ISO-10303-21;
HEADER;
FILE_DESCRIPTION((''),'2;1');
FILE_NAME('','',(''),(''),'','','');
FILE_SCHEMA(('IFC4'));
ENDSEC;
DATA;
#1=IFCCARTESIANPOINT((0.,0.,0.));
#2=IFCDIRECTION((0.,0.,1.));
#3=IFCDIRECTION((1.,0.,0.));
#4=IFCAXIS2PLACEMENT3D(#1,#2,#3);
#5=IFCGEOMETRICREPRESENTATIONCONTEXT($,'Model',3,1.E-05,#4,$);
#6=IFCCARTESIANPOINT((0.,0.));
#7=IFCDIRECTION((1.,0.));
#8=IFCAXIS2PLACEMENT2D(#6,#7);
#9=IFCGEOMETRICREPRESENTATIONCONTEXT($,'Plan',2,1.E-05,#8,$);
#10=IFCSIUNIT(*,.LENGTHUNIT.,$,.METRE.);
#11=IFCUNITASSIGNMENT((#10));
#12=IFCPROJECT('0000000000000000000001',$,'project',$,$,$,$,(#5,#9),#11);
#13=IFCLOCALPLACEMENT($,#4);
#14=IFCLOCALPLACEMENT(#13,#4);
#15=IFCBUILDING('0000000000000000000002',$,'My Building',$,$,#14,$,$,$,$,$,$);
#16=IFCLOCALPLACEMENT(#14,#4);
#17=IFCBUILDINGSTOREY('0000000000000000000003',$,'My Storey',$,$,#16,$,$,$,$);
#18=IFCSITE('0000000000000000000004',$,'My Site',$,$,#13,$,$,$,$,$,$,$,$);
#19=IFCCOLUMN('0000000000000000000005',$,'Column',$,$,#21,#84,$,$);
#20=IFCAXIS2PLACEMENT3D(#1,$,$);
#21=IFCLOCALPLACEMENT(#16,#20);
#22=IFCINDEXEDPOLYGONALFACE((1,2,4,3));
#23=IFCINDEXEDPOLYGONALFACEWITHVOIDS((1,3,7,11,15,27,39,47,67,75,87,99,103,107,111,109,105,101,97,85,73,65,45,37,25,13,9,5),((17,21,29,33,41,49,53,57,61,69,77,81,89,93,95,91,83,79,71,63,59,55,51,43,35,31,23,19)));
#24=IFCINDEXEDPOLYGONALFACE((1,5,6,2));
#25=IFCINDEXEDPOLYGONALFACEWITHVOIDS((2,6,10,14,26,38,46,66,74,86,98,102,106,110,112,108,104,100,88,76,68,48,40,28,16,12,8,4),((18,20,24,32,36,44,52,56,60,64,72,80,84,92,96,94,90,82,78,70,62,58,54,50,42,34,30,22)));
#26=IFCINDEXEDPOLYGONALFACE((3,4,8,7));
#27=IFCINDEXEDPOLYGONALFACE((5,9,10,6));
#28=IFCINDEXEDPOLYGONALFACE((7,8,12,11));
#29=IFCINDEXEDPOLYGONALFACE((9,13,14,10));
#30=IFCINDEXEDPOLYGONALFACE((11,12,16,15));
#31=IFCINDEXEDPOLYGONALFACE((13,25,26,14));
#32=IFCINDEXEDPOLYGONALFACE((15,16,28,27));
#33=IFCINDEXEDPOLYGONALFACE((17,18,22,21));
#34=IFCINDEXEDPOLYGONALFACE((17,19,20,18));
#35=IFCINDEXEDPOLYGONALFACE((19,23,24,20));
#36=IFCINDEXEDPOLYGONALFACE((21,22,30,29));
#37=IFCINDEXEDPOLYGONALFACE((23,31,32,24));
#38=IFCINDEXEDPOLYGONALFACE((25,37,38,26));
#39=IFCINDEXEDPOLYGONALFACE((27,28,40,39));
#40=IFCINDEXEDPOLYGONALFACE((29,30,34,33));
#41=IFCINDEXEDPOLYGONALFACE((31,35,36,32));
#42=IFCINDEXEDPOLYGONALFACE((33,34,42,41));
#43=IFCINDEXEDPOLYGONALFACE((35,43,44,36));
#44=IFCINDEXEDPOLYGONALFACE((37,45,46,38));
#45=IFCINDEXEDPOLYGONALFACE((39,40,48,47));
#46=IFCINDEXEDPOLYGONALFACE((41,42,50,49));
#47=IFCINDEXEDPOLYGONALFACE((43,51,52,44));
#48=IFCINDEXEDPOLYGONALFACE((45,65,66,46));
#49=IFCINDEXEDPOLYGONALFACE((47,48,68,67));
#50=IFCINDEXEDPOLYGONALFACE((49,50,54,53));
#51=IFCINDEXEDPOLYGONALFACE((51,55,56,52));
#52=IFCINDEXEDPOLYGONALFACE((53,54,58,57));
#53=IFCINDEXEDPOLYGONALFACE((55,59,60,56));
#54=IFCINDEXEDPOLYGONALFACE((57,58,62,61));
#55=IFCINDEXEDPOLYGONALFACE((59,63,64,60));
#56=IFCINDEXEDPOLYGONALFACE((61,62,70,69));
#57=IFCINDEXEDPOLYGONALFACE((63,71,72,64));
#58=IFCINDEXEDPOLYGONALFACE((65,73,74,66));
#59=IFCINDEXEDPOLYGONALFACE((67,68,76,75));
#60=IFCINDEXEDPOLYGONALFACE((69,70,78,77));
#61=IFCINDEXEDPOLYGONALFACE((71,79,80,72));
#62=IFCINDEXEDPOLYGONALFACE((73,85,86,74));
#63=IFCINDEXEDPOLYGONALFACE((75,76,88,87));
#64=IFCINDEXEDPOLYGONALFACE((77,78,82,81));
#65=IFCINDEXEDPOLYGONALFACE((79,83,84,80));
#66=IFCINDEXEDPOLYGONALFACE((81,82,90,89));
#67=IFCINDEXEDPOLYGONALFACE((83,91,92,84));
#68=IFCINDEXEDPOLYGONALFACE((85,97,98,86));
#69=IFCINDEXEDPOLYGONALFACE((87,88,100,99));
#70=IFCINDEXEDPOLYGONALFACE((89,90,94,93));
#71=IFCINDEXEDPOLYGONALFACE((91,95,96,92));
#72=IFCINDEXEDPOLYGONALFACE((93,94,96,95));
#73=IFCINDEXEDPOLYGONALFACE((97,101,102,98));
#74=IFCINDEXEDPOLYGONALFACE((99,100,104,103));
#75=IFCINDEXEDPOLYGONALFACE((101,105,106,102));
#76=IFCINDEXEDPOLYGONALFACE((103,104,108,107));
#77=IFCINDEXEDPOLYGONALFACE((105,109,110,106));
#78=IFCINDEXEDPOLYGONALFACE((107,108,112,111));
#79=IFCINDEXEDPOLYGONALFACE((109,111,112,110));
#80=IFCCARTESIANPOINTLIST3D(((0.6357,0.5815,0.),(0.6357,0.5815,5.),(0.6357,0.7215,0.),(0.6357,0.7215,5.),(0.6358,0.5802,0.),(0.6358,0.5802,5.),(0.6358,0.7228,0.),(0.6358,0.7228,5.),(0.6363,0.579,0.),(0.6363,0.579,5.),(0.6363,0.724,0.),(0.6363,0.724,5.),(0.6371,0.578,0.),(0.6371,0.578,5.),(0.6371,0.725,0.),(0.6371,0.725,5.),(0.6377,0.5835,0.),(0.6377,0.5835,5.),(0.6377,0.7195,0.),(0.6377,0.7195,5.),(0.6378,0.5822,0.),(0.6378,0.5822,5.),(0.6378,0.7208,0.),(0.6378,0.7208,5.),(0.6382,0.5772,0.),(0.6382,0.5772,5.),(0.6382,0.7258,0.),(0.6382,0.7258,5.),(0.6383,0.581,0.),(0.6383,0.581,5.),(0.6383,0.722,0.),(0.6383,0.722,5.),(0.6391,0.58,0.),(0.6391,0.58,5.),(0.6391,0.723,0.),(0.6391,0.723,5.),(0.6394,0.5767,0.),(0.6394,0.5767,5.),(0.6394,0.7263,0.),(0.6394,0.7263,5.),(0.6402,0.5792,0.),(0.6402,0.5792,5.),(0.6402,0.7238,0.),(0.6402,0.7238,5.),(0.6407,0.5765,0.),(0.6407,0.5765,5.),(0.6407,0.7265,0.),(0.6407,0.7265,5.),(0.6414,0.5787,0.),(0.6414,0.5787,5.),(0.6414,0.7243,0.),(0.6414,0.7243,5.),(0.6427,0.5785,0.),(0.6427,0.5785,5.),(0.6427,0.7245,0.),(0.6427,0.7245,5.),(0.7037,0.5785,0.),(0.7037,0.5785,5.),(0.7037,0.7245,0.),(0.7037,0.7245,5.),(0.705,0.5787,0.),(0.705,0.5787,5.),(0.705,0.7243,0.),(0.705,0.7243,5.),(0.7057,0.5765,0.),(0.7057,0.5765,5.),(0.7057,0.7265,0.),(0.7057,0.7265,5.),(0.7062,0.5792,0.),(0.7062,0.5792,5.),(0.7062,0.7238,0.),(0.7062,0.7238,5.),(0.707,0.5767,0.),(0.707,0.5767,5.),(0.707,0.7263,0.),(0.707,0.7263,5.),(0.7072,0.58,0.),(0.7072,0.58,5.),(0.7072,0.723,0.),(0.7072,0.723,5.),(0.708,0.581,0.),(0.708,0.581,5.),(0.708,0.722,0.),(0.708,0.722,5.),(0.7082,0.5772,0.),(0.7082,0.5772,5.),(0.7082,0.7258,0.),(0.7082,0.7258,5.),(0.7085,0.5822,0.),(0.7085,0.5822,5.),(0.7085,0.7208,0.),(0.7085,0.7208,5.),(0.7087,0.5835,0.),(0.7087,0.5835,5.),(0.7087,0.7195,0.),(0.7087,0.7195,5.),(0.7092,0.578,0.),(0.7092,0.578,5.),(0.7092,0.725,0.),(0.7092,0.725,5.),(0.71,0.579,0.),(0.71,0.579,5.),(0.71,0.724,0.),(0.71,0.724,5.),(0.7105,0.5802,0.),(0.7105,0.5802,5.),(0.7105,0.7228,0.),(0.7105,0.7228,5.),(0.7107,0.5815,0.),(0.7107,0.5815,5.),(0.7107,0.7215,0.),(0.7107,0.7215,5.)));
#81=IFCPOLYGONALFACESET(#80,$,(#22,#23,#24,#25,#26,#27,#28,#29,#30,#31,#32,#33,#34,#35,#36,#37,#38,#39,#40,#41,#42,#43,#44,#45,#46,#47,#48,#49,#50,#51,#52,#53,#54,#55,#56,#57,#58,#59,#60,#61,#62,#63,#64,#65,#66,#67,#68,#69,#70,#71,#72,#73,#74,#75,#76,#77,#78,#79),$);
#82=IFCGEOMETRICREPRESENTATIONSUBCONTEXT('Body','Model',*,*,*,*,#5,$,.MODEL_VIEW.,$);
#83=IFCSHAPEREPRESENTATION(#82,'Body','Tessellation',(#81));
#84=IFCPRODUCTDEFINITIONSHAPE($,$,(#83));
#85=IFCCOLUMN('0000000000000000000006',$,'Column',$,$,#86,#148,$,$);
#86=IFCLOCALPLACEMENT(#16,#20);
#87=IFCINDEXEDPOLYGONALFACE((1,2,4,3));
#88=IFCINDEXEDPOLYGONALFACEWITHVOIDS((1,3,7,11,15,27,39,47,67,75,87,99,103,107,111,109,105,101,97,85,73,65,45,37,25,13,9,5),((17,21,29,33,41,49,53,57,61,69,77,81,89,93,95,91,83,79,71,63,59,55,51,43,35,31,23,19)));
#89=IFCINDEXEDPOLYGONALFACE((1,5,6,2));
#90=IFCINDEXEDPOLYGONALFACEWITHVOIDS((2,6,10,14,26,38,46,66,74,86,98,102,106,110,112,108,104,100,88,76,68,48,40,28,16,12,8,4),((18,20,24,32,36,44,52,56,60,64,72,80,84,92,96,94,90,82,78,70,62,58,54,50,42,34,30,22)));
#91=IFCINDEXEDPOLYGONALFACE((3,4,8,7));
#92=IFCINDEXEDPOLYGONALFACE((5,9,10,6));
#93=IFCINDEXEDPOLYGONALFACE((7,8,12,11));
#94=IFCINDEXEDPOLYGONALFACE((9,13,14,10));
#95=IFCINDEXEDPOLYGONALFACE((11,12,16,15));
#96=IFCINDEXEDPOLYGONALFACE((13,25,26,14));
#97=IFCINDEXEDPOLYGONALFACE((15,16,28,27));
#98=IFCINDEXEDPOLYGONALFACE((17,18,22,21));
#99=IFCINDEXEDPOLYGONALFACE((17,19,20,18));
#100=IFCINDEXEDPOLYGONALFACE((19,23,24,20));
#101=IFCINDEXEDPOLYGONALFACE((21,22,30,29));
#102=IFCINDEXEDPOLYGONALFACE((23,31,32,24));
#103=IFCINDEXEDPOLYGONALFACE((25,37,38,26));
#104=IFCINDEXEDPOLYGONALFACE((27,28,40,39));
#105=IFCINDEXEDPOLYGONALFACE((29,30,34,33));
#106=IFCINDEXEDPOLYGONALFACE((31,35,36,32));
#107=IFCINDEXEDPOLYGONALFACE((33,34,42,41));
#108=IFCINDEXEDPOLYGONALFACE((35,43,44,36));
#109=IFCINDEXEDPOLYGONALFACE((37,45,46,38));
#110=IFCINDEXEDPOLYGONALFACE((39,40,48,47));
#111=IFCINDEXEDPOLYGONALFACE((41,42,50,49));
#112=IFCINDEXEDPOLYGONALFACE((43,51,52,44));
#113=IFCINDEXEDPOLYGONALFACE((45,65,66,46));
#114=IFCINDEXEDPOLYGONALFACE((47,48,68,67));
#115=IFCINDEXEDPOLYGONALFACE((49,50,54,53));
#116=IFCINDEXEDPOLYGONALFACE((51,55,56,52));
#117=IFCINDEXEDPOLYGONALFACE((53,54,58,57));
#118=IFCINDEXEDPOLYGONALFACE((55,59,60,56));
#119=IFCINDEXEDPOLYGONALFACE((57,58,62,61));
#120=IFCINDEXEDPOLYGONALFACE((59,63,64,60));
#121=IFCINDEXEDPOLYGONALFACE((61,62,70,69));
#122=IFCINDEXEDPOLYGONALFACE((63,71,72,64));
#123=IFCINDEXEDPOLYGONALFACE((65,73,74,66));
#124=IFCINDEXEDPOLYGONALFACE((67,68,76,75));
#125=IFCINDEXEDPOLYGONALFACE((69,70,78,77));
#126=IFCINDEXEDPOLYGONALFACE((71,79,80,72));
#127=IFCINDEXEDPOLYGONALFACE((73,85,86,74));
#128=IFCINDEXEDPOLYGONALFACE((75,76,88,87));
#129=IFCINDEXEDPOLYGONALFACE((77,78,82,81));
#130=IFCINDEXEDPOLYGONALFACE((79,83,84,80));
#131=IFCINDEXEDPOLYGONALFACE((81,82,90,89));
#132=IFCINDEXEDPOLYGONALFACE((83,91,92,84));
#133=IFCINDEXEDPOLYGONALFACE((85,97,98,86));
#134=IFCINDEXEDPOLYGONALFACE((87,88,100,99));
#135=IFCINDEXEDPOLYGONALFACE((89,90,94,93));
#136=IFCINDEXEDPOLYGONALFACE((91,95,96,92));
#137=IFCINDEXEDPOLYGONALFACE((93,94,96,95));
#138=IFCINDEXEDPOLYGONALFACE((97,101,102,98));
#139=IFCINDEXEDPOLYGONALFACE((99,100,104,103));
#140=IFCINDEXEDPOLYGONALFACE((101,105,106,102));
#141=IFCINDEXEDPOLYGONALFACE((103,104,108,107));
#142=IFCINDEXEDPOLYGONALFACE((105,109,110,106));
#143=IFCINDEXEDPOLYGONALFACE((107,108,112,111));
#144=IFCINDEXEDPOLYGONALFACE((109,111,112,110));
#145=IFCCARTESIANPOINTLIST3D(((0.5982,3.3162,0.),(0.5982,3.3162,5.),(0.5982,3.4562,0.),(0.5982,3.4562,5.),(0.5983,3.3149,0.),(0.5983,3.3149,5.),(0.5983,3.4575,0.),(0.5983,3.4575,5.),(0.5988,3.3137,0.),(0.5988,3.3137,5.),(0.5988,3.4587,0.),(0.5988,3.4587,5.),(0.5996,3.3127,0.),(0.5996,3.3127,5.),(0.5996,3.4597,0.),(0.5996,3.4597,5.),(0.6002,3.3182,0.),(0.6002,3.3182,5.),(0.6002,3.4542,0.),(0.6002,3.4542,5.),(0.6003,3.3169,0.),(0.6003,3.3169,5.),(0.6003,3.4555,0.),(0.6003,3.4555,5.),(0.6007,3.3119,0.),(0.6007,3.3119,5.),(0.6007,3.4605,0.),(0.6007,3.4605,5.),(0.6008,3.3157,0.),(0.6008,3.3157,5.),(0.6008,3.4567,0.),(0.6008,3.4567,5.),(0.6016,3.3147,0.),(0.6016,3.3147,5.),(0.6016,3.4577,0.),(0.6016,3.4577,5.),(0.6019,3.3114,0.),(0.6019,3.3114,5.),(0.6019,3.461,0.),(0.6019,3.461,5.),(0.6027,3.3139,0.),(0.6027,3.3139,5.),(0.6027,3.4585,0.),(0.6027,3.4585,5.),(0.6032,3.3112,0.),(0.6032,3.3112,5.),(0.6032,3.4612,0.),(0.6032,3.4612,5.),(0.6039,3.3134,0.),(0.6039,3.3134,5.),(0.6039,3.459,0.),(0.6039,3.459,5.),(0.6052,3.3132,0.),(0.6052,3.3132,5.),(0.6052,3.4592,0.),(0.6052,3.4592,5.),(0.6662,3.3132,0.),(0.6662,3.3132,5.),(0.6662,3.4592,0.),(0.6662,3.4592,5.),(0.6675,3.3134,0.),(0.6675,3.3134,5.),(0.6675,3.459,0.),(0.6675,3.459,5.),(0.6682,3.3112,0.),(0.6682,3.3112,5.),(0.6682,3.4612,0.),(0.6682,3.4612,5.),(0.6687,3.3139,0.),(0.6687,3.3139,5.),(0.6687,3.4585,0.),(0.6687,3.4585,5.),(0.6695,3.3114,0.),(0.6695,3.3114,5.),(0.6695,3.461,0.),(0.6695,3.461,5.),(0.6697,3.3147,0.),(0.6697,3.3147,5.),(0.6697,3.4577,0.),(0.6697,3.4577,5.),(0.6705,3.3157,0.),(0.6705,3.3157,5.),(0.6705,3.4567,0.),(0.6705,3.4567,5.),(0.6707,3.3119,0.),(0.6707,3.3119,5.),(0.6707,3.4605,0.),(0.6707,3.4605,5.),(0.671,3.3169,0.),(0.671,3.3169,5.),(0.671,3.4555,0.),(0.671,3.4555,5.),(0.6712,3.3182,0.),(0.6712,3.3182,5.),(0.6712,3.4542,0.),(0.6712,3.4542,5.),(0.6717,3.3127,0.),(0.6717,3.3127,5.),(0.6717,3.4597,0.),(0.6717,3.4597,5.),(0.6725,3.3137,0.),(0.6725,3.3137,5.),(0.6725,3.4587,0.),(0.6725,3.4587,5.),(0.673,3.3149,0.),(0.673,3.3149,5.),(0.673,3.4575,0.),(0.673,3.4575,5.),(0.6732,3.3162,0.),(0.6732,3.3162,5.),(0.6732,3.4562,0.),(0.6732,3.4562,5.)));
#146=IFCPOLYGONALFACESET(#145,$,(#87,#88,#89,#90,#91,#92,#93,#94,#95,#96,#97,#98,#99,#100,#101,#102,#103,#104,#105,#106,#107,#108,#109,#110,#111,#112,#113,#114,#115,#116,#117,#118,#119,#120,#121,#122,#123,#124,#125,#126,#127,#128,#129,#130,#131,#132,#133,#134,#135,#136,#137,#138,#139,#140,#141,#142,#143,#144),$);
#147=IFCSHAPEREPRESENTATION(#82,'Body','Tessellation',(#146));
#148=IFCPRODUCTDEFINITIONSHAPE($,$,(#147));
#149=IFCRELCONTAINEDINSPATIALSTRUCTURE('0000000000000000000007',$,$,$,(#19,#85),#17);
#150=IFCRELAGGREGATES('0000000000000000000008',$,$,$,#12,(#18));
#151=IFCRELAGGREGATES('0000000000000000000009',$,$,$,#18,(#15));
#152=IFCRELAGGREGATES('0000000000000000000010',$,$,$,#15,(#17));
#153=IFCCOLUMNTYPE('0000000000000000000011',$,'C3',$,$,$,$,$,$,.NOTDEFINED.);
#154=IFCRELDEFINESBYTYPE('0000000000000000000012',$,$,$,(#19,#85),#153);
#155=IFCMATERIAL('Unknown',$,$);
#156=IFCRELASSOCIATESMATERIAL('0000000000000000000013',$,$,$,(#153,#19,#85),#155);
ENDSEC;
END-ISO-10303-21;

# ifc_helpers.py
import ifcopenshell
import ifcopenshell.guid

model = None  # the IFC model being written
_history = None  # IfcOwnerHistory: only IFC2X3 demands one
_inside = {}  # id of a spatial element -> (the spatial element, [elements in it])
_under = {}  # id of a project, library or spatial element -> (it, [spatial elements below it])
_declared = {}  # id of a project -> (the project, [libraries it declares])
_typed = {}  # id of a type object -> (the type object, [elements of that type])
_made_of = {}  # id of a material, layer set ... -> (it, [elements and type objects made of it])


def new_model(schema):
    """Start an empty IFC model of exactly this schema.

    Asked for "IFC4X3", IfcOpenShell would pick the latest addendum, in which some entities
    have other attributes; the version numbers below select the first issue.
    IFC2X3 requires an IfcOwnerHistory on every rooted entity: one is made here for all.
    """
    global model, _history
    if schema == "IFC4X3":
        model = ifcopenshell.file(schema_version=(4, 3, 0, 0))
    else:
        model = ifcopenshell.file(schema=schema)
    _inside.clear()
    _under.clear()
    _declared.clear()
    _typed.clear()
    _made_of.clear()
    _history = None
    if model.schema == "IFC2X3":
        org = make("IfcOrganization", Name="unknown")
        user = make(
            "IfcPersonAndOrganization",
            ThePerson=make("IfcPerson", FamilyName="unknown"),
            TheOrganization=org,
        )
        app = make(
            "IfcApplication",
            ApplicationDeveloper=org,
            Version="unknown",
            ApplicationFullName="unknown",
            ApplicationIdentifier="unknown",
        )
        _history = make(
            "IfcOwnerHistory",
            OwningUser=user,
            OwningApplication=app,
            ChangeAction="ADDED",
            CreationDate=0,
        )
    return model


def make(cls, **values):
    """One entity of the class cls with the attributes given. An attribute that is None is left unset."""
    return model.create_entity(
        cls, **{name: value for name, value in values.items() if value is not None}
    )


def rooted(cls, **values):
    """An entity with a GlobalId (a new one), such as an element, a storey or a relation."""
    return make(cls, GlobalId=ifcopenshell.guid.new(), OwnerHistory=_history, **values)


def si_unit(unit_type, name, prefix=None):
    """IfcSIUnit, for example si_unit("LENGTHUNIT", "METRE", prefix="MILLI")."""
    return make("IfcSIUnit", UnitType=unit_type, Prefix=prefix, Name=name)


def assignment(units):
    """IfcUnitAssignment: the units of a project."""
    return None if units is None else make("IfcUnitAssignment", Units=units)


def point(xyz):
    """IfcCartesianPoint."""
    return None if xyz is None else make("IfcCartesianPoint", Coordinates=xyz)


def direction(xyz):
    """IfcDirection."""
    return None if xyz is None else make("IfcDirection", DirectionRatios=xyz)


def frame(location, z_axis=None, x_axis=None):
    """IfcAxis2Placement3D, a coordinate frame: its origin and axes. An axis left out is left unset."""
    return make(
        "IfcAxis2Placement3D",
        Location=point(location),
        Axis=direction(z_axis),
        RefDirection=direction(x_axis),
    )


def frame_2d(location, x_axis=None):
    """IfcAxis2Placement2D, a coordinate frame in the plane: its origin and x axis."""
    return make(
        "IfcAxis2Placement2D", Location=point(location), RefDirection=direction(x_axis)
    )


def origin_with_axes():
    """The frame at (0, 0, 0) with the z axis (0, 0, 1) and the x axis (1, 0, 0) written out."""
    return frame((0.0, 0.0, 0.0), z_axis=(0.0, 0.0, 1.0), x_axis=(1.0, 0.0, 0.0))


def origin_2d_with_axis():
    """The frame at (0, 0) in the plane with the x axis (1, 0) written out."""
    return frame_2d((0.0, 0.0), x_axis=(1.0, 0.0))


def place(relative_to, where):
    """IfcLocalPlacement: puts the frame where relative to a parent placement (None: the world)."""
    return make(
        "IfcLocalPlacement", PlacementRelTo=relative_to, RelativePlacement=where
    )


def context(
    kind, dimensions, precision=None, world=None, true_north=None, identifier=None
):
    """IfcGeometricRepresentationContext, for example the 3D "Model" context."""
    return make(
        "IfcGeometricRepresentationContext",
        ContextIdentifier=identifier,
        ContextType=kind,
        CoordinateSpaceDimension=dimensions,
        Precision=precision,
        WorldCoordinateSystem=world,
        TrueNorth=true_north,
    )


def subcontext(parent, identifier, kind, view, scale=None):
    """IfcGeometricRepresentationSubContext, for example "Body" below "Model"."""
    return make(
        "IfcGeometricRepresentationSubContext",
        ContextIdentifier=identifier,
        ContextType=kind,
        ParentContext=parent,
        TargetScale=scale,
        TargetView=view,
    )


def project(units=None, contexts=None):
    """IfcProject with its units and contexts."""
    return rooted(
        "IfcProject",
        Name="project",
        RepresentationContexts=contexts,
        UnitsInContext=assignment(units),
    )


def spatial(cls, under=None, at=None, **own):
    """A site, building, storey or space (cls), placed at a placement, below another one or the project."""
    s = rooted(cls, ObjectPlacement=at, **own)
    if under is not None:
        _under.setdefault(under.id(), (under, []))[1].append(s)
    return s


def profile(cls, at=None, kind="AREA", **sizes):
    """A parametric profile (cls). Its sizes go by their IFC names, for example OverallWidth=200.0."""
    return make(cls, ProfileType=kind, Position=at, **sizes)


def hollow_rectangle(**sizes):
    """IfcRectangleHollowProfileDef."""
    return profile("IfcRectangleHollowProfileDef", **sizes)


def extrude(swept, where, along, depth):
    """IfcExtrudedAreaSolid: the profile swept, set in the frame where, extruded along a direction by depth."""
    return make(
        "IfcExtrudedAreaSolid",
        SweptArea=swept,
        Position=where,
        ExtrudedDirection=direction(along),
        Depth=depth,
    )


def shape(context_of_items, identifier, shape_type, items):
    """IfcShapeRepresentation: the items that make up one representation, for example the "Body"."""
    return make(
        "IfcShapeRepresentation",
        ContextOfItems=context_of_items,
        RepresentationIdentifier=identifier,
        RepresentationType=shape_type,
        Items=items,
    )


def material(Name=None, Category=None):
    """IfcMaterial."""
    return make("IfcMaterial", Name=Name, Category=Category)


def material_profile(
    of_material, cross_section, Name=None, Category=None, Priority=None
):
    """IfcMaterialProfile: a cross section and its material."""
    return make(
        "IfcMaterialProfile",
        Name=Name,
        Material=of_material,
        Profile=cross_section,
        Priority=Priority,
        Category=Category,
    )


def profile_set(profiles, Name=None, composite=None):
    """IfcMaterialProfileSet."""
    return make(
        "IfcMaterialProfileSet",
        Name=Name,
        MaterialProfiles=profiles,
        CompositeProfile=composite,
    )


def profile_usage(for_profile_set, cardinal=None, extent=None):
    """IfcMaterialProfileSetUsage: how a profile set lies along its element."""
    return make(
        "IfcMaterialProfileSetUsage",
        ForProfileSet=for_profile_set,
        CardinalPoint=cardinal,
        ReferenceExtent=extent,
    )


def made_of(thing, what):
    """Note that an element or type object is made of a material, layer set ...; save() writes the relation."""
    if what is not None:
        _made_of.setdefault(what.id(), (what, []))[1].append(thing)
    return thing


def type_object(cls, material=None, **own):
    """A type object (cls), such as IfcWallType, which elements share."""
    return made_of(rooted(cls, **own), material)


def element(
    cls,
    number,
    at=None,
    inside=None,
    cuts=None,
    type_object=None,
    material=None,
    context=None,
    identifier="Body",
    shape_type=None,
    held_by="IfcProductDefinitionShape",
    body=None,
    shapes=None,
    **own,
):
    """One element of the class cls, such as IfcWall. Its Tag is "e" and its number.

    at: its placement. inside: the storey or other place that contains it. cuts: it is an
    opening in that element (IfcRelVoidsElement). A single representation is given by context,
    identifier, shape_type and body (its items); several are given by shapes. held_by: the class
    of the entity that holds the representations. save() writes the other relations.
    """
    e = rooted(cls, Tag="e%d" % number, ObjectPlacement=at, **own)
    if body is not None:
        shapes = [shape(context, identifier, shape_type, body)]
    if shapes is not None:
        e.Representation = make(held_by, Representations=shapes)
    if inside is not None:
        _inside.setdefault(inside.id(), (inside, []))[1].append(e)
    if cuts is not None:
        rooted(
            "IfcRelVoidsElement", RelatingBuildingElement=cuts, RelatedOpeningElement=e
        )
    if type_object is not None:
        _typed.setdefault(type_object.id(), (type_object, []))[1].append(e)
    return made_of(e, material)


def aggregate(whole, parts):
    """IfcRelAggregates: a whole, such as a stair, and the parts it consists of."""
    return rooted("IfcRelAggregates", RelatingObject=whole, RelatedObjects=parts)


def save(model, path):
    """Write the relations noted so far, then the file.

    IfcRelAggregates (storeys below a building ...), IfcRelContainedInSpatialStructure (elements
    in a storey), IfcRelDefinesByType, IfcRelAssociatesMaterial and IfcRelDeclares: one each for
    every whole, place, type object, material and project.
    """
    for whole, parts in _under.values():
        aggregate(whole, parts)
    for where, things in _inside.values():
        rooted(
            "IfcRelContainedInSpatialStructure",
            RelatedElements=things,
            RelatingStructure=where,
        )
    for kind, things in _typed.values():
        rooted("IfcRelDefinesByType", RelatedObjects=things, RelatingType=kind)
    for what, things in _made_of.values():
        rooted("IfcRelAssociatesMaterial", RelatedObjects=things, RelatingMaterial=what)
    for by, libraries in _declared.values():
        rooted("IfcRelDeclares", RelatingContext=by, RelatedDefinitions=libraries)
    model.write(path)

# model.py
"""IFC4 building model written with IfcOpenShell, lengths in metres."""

from ifc_helpers import new_model, si_unit, frame, origin_with_axes, origin_2d_with_axis, place, context, subcontext, project, spatial, hollow_rectangle, extrude, material, material_profile, profile_set, profile_usage, type_object, element, save


model = new_model("IFC4")

# Units and contexts
model_context = context("Model", 3, precision=1e-05, world=origin_with_axes())
plan_context = context("Plan", 2, precision=1e-05, world=origin_2d_with_axis())
body_context = subcontext(model_context, "Body", "Model", "MODEL_VIEW")
ifc_project = project(units=[si_unit("LENGTHUNIT", "METRE")], contexts=[model_context, plan_context])

# Site, building, storey
site_placement = place(None, origin_with_axes())
site = spatial("IfcSite", under=ifc_project, at=site_placement, Name="My Site")
building_placement = place(site_placement, origin_with_axes())
building = spatial("IfcBuilding", under=site, at=building_placement, Name="My Building")
storey_placement = place(building_placement, origin_with_axes())
storey = spatial("IfcBuildingStorey", under=building, at=storey_placement, Name="My Storey")

# Columns
ifc_material = material(Name="Unknown")
ifc_material_profile_1 = material_profile(ifc_material, hollow_rectangle(XDim=0.075, YDim=0.15, WallThickness=0.002, InnerFilletRadius=0.005, OuterFilletRadius=0.005))
ifc_profile_set_1 = profile_set([ifc_material_profile_1])
column_type = type_object("IfcColumnType", Name="C3", PredefinedType="NOTDEFINED", material=ifc_profile_set_1)
ifc_profile_usage_1 = profile_usage(ifc_profile_set_1, cardinal=5)
column_1_placement = place(storey_placement, frame((0.6732, 0.6515, 0.0), z_axis=(0.0, 0.0, 1.0), x_axis=(1.0, 0.0, 0.0)))
element("IfcColumn", 1, at=column_1_placement, inside=storey, type_object=column_type, material=ifc_profile_usage_1, Name="Column", context=body_context, shape_type="SweptSolid", body=[
    extrude(hollow_rectangle(XDim=0.075, YDim=0.15, WallThickness=0.002, InnerFilletRadius=0.005, OuterFilletRadius=0.005), origin_with_axes(), (0.0, 0.0, 1.0), 5.0),
])
ifc_profile_usage_2 = profile_usage(ifc_profile_set_1, cardinal=5)
column_2_placement = place(storey_placement, frame((0.6357, 3.3862, 0.0), z_axis=(0.0, 0.0, 1.0), x_axis=(1.0, 0.0, 0.0)))
element("IfcColumn", 2, at=column_2_placement, inside=storey, type_object=column_type, material=ifc_profile_usage_2, Name="Column", context=body_context, shape_type="SweptSolid", body=[
    extrude(hollow_rectangle(XDim=0.075, YDim=0.15, WallThickness=0.002, InnerFilletRadius=0.005, OuterFilletRadius=0.005), origin_with_axes(), (0.0, 0.0, 1.0), 5.0),
])

save(model, "model.ifc")
